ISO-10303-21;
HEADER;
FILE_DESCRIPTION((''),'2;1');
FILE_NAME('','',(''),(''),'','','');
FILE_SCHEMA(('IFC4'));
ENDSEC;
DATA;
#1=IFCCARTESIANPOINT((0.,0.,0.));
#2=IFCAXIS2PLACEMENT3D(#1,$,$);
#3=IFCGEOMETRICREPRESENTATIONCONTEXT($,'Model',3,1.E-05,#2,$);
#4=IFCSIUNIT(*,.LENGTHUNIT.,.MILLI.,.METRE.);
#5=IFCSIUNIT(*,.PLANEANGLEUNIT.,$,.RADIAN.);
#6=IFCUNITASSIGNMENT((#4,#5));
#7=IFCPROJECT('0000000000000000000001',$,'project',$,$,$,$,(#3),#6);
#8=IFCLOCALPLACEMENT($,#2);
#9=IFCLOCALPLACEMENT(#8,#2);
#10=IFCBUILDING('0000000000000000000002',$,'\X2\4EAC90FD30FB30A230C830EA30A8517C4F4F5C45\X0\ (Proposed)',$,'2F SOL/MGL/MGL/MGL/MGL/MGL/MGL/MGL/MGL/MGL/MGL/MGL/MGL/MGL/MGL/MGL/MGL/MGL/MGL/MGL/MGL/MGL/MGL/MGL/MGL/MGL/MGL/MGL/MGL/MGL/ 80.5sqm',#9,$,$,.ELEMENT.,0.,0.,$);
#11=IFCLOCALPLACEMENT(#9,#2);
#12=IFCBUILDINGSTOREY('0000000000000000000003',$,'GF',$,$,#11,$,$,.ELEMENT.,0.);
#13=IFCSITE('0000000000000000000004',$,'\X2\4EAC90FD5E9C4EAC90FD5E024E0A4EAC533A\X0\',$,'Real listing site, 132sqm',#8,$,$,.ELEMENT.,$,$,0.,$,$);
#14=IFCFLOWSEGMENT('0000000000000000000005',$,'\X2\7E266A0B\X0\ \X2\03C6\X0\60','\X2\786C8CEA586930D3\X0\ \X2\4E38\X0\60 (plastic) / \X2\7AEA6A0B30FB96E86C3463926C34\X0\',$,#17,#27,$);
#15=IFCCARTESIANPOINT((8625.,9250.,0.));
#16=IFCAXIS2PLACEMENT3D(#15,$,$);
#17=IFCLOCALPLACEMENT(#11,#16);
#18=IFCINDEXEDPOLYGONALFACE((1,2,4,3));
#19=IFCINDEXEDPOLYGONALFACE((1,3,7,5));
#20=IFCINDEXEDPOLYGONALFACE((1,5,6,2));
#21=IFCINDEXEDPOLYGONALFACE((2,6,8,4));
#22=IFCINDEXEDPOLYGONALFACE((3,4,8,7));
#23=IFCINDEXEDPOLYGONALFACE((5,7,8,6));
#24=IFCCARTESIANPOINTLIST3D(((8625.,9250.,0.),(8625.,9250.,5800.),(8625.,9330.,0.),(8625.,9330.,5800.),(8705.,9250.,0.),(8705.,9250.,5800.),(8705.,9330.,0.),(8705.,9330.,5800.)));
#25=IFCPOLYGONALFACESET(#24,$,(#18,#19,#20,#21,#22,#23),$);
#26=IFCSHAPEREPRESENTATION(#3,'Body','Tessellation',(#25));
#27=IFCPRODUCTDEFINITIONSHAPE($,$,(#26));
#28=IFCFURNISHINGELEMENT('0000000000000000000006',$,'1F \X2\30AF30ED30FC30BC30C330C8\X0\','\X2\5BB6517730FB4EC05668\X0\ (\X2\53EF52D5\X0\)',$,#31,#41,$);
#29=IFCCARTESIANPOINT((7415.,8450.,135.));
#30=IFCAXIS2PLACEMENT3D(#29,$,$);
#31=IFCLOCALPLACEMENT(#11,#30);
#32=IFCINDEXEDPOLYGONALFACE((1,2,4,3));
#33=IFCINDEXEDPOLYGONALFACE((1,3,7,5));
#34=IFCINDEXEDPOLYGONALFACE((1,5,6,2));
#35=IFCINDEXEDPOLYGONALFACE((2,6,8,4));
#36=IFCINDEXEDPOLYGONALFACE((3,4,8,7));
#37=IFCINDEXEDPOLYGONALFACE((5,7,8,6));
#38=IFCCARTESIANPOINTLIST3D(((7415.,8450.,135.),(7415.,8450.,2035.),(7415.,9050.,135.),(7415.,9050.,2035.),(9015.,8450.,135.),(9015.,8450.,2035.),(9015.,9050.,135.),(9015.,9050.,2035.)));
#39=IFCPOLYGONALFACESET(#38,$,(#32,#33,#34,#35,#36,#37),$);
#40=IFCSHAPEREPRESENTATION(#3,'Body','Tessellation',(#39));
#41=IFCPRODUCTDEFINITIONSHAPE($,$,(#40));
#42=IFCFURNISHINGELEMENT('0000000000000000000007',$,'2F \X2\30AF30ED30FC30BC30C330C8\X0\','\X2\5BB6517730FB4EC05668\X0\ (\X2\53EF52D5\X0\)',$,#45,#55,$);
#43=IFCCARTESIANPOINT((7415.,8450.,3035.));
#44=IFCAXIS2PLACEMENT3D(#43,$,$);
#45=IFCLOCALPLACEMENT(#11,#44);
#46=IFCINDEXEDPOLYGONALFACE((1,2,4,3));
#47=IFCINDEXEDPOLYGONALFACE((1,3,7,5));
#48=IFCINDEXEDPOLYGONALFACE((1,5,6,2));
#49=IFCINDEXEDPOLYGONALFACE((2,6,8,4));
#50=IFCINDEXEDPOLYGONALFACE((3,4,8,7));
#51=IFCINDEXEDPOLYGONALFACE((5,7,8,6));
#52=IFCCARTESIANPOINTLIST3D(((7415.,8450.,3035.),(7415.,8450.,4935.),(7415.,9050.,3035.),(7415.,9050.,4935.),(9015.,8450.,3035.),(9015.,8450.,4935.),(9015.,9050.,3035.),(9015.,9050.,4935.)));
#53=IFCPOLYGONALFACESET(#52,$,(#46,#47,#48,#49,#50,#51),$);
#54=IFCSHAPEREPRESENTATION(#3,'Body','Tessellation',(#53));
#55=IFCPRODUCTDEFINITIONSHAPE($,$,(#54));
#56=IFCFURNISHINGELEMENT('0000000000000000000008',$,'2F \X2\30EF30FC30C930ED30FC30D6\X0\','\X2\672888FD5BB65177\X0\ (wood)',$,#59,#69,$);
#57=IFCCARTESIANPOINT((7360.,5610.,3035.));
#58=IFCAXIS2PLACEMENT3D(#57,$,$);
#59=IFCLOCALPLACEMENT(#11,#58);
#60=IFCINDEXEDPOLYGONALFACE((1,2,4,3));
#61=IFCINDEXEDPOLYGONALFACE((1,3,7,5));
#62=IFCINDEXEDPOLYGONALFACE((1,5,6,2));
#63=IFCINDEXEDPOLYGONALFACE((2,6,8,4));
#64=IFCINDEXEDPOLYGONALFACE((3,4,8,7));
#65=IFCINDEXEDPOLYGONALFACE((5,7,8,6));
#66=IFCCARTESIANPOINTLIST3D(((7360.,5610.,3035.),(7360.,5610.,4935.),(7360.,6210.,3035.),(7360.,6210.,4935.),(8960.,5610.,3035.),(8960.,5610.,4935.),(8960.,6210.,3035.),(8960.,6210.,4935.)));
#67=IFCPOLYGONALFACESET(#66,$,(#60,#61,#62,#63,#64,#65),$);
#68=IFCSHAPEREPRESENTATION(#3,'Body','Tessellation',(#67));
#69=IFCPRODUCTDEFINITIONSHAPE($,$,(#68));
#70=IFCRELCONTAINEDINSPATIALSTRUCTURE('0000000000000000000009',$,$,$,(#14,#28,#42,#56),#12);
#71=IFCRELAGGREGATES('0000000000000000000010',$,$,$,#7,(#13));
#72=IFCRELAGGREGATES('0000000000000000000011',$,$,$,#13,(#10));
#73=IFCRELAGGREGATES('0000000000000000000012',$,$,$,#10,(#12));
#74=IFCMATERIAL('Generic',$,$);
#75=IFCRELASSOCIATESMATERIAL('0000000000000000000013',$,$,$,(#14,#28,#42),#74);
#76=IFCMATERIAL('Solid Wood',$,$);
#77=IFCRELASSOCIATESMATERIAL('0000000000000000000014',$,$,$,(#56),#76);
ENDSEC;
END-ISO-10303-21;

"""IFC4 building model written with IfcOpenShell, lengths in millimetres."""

from ifc_helpers import new_model, si_unit, frame, frame_2d, origin, place, context, project, spatial, rectangle, extrude, material, element, save


model = new_model("IFC4")

# Units and contexts
model_context = context("Model", 3, precision=1e-05, world=origin())
ifc_project = project(units=[si_unit("LENGTHUNIT", "METRE", prefix="MILLI"), si_unit("PLANEANGLEUNIT", "RADIAN")], contexts=[model_context])

# Site, building, storey
site_placement = place(None, origin())
site = spatial("IfcSite", under=ifc_project, at=site_placement, Name="京都府京都市上京区", ObjectType="Real listing site, 132sqm", CompositionType="ELEMENT", RefElevation=0.0)
building_placement = place(site_placement, origin())
building = spatial("IfcBuilding", under=site, at=building_placement, Name="京都・アトリエ兼住居 (Proposed)", ObjectType="2F SOL/MGL/MGL/MGL/MGL/MGL/MGL/MGL/MGL/MGL/MGL/MGL/MGL/MGL/MGL/MGL/MGL/MGL/MGL/MGL/MGL/MGL/MGL/MGL/MGL/MGL/MGL/MGL/MGL/MGL/ 80.5sqm", CompositionType="ELEMENT", ElevationOfRefHeight=0.0, ElevationOfTerrain=0.0)
storey_placement = place(building_placement, origin())
storey = spatial("IfcBuildingStorey", under=building, at=storey_placement, Name="GF", CompositionType="ELEMENT", Elevation=0.0)

# Shared definitions
ifc_material_1 = material(Name="Solid Wood")

# Shared definitions
ifc_material_2 = material(Name="Generic")

# Flow segment
flow_segment_placement = place(storey_placement, frame((8625.0, 9250.0, 0.0)))
element("IfcFlowSegment", 1, at=flow_segment_placement, inside=storey, material=ifc_material_2, Name="縦樋 φ60", Description="硬質塩ビ 丸60 (plastic) / 竪樋・雨水排水", context=model_context, shape_type="SweptSolid", body=[
    extrude(rectangle(XDim=80.0, YDim=80.0, at=frame_2d((40.0, 40.0))), frame((8625.0, 9250.0, 0.0)), (0.0, 0.0, 1.0), 5800.0),
])

# Furnishing elements
furnishing_1_placement = place(storey_placement, frame((7415.0, 8450.0, 135.0)))
element("IfcFurnishingElement", 2, at=furnishing_1_placement, inside=storey, material=ifc_material_2, Name="1F クローゼット", Description="家具・什器 (可動)", context=model_context, shape_type="SweptSolid", body=[
    extrude(rectangle(XDim=1600.0, YDim=600.0, at=frame_2d((800.0, 300.0))), frame((7415.0, 8450.0, 135.0)), (0.0, 0.0, 1.0), 1900.0),
])
furnishing_2_placement = place(storey_placement, frame((7415.0, 8450.0, 3035.0)))
element("IfcFurnishingElement", 3, at=furnishing_2_placement, inside=storey, material=ifc_material_2, Name="2F クローゼット", Description="家具・什器 (可動)", context=model_context, shape_type="SweptSolid", body=[
    extrude(rectangle(XDim=1600.0, YDim=600.0, at=frame_2d((800.0, 300.0))), frame((7415.0, 8450.0, 3035.0)), (0.0, 0.0, 1.0), 1900.0),
])
furnishing_3_placement = place(storey_placement, frame((7360.0, 5610.0, 3035.0)))
element("IfcFurnishingElement", 4, at=furnishing_3_placement, inside=storey, material=ifc_material_1, Name="2F ワードローブ", Description="木製家具 (wood)", context=model_context, shape_type="SweptSolid", body=[
    extrude(rectangle(XDim=1600.0, YDim=600.0, at=frame_2d((800.0, 300.0))), frame((7360.0, 5610.0, 3035.0)), (0.0, 0.0, 1.0), 1900.0),
])

save(model, "model.ifc")
